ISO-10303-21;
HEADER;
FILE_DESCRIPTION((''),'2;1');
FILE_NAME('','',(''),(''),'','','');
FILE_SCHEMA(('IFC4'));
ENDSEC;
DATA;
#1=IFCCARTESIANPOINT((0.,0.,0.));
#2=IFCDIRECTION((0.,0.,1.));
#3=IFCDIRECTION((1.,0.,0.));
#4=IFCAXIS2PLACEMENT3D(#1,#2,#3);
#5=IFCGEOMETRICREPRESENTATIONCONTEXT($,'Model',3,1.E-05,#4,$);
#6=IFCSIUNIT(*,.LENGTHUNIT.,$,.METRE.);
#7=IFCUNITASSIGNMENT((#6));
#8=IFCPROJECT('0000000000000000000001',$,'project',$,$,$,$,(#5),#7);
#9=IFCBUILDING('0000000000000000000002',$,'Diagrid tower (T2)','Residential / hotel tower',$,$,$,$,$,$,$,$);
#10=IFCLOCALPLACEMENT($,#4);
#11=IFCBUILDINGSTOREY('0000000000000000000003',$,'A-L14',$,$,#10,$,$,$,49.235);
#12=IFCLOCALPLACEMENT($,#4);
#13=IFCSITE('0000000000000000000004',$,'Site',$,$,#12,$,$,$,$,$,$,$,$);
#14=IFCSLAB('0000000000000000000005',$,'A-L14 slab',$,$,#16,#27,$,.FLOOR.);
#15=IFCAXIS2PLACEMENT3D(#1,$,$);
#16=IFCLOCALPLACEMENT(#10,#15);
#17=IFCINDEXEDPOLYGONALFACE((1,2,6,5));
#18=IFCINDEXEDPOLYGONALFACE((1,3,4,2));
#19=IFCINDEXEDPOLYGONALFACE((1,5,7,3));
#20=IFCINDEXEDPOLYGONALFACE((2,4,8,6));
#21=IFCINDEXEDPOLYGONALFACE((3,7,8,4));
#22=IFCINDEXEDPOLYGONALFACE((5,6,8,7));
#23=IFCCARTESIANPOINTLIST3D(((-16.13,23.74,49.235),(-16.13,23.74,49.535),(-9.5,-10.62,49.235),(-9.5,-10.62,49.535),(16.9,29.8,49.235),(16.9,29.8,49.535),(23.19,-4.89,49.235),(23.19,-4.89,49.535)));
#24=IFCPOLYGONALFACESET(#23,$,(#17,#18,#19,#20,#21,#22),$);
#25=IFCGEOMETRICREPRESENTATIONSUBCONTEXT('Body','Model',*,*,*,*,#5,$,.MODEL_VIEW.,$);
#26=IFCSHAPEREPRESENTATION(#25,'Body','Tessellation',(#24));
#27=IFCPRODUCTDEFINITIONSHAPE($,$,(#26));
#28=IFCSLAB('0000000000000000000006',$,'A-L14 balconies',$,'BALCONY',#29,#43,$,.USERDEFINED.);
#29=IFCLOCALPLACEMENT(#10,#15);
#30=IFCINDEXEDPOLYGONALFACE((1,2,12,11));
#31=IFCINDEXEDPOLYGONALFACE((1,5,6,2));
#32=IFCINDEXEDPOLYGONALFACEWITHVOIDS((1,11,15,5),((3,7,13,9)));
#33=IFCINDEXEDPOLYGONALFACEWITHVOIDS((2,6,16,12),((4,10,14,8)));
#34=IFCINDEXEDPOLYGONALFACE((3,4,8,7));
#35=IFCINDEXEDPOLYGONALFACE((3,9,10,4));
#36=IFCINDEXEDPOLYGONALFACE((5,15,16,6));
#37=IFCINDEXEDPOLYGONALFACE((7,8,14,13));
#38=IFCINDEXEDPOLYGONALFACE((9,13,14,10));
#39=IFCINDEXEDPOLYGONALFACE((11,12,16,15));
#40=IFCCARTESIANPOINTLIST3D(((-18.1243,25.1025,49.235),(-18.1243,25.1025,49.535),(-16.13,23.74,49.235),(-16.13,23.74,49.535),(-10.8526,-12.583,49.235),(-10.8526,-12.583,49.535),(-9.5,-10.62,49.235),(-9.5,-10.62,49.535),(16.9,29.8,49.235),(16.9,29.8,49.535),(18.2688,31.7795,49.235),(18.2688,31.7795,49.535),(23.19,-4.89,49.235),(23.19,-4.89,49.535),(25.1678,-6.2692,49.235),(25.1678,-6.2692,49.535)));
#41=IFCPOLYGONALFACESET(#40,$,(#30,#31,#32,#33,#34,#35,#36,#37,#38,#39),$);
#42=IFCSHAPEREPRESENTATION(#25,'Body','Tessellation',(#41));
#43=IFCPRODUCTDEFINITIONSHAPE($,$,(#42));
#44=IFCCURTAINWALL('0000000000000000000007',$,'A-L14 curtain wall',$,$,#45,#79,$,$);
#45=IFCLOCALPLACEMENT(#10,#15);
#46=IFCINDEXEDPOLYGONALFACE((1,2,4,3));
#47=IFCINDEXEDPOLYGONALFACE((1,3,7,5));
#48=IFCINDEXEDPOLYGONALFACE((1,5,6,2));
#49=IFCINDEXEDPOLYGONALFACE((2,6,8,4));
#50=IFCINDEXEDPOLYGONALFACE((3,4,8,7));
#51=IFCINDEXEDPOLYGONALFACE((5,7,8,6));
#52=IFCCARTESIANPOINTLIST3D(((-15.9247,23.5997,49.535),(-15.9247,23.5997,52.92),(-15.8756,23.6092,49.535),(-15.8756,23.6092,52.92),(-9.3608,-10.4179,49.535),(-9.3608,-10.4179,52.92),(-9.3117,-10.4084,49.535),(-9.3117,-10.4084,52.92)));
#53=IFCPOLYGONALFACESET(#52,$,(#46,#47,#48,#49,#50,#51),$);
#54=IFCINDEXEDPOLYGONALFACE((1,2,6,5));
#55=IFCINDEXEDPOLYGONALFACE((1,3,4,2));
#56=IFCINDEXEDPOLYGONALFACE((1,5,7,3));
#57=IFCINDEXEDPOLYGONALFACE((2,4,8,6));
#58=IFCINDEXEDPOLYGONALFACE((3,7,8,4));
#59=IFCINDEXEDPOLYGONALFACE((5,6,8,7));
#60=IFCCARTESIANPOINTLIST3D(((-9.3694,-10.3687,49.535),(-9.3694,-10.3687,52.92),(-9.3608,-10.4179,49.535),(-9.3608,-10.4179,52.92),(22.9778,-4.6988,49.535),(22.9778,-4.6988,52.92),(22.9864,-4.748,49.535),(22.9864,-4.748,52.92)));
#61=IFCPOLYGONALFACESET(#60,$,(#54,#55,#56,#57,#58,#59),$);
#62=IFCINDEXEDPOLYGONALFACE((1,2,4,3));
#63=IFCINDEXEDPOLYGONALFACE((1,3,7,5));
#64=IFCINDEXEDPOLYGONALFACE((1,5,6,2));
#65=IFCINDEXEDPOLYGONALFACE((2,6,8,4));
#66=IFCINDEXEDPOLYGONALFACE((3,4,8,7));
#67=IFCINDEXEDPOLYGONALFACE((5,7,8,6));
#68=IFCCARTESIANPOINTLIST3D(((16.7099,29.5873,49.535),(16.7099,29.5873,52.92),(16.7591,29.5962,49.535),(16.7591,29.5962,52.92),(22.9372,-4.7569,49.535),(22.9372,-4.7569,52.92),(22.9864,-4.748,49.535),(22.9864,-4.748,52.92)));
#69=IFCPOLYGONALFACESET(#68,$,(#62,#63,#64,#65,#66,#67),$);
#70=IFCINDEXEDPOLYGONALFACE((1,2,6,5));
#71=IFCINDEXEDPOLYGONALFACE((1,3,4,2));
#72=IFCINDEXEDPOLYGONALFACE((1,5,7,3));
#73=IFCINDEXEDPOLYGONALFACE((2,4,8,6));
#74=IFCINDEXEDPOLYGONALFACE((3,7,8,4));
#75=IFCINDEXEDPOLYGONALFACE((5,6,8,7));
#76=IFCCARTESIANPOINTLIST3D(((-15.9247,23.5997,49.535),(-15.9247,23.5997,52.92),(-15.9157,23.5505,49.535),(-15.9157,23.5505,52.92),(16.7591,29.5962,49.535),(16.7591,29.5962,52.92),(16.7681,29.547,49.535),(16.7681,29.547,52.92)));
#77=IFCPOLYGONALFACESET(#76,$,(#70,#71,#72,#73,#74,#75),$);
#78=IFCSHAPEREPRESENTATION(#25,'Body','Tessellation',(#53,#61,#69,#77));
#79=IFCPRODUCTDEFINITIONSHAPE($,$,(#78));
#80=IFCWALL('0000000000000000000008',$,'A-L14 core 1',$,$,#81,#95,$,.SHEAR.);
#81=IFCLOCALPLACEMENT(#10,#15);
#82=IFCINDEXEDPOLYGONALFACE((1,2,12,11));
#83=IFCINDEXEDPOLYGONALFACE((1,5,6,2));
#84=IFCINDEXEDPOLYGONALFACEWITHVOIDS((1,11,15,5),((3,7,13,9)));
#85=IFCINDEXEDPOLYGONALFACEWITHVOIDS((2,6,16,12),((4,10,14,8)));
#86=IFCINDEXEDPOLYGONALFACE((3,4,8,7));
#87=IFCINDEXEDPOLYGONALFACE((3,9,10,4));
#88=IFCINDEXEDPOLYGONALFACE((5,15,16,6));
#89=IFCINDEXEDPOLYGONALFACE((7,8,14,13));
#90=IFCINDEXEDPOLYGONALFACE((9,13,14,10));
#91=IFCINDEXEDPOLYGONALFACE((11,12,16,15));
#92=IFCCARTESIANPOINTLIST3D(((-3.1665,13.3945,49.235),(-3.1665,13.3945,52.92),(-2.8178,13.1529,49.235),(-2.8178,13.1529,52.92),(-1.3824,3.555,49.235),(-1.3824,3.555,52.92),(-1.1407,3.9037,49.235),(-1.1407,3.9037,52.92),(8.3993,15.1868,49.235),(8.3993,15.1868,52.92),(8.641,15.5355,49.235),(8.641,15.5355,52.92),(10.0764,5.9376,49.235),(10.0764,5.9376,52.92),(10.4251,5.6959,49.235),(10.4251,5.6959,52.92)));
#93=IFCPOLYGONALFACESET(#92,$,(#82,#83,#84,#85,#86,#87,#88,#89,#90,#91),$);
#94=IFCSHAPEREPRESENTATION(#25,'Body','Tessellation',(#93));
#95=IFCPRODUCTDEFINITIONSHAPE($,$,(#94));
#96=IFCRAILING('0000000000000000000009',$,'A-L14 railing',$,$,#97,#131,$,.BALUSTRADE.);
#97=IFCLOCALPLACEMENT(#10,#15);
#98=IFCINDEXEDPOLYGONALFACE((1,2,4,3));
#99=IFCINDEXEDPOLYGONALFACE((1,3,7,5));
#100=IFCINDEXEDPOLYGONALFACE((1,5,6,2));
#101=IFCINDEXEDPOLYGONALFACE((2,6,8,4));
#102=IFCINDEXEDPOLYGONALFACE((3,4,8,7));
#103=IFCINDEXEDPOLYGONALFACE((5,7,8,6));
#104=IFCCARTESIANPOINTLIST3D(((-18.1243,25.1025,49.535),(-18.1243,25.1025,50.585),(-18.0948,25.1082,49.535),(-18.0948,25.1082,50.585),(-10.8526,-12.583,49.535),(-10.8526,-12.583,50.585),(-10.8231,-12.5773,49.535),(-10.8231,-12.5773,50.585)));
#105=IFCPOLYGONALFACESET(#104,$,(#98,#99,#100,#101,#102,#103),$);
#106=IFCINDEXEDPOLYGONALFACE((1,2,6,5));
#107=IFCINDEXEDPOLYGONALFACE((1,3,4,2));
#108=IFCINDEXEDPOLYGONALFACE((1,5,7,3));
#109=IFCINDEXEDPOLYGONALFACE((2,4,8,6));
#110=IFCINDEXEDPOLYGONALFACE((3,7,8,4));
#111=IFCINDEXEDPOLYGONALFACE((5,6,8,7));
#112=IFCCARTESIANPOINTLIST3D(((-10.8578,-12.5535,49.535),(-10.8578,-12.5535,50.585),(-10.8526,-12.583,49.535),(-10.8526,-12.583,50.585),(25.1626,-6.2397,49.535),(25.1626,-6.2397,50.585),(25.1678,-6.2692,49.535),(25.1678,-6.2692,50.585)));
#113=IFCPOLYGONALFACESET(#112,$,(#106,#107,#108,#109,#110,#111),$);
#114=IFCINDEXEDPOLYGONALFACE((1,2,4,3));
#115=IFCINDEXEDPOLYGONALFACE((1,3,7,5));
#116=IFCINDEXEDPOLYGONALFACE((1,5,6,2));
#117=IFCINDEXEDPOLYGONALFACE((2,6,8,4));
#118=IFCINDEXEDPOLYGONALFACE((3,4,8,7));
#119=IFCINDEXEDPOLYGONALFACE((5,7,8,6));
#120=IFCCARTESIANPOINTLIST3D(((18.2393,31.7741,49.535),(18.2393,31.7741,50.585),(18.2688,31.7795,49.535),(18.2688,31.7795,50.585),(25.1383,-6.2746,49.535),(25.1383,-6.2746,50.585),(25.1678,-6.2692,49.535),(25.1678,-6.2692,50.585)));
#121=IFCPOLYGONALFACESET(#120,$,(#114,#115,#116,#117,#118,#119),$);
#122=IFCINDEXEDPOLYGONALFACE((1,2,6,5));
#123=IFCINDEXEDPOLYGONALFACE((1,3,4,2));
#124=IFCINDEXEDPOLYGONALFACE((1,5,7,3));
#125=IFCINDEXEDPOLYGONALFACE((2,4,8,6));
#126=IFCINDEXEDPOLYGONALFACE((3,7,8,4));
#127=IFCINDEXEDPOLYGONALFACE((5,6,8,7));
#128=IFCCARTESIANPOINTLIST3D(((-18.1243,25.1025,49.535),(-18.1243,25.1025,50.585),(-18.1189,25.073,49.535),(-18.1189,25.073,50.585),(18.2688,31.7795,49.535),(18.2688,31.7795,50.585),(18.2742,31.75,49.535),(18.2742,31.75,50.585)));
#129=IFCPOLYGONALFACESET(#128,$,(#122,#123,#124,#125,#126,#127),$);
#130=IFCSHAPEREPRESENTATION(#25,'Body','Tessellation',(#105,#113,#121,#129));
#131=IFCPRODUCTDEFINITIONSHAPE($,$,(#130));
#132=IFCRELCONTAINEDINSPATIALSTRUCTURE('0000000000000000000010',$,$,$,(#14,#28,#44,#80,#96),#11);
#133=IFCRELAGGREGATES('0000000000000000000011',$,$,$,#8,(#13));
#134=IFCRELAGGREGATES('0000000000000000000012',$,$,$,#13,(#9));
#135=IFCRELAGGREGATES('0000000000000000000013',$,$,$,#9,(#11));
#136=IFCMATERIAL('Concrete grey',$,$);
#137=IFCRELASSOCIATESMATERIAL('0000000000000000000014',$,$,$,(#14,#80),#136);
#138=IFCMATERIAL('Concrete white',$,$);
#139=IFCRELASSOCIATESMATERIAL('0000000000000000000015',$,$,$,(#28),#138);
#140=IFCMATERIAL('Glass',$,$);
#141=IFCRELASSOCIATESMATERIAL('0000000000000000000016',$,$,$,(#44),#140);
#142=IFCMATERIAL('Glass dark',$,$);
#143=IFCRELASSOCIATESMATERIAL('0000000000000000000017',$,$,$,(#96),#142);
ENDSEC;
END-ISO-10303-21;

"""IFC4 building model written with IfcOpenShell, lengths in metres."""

from ifc_helpers import new_model, si_unit, frame, origin_with_axes, place, context, subcontext, project, spatial, polyline, outline, extrude, material, element, save


model = new_model("IFC4")

# Units and contexts
model_context = context("Model", 3, precision=1e-05, world=origin_with_axes())
body_context = subcontext(model_context, "Body", "Model", "MODEL_VIEW")
ifc_project = project(units=[si_unit("LENGTHUNIT", "METRE")], contexts=[model_context])

# Site, building, storey
site_placement = place(None, origin_with_axes())
site = spatial("IfcSite", under=ifc_project, at=site_placement, Name="Site")
building = spatial("IfcBuilding", under=site, Name="Diagrid tower (T2)", Description="Residential / hotel tower")
storey_placement = place(None, origin_with_axes())
storey = spatial("IfcBuildingStorey", under=building, at=storey_placement, Name="A-L14", Elevation=49.235)

# Slabs
ifc_material_1 = material(Name="Concrete grey")
slab_1_placement = place(storey_placement, origin_with_axes())
element("IfcSlab", 1, at=slab_1_placement, inside=storey, material=ifc_material_1, Name="A-L14 slab", PredefinedType="FLOOR", context=body_context, shape_type="SweptSolid", body=[
    extrude(outline(polyline([(-16.13, 23.74), (-9.5, -10.62), (23.19, -4.89), (16.9, 29.8), (-16.13, 23.74)])), frame((0.0, 0.0, 49.235), z_axis=(0.0, 0.0, 1.0), x_axis=(1.0, 0.0, 0.0)), (0.0, 0.0, 1.0), 0.3),
])
ifc_material_2 = material(Name="Concrete white")
slab_2_placement = place(storey_placement, origin_with_axes())
element("IfcSlab", 2, at=slab_2_placement, inside=storey, material=ifc_material_2, Name="A-L14 balconies", ObjectType="BALCONY", PredefinedType="USERDEFINED", context=body_context, shape_type="SweptSolid", body=[
    extrude(outline(polyline([(-18.1243, 25.1025), (-10.8526, -12.583), (25.1678, -6.2692), (18.2688, 31.7795), (-18.1243, 25.1025)]), holes=[polyline([(-16.13, 23.74), (-9.5, -10.62), (23.19, -4.89), (16.9, 29.8), (-16.13, 23.74)])]), frame((0.0, 0.0, 49.235), z_axis=(0.0, 0.0, 1.0), x_axis=(1.0, 0.0, 0.0)), (0.0, 0.0, 1.0), 0.3),
])

# Curtain wall
ifc_material_3 = material(Name="Glass")
curtain_wall_placement = place(storey_placement, origin_with_axes())
element("IfcCurtainWall", 3, at=curtain_wall_placement, inside=storey, material=ifc_material_3, Name="A-L14 curtain wall", context=body_context, shape_type="SweptSolid", body=[
    extrude(outline(polyline([(-15.9247, 23.5997), (-9.3608, -10.4179), (-9.3117, -10.4084), (-15.8756, 23.6092), (-15.9247, 23.5997)])), frame((0.0, 0.0, 49.535), z_axis=(0.0, 0.0, 1.0), x_axis=(1.0, 0.0, 0.0)), (0.0, 0.0, 1.0), 3.385),
    extrude(outline(polyline([(-9.3608, -10.4179), (22.9864, -4.748), (22.9778, -4.6988), (-9.3694, -10.3687), (-9.3608, -10.4179)])), frame((0.0, 0.0, 49.535), z_axis=(0.0, 0.0, 1.0), x_axis=(1.0, 0.0, 0.0)), (0.0, 0.0, 1.0), 3.385),
    extrude(outline(polyline([(22.9864, -4.748), (16.7591, 29.5962), (16.7099, 29.5873), (22.9372, -4.7569), (22.9864, -4.748)])), frame((0.0, 0.0, 49.535), z_axis=(0.0, 0.0, 1.0), x_axis=(1.0, 0.0, 0.0)), (0.0, 0.0, 1.0), 3.385),
    extrude(outline(polyline([(16.7591, 29.5962), (-15.9247, 23.5997), (-15.9157, 23.5505), (16.7681, 29.547), (16.7591, 29.5962)])), frame((0.0, 0.0, 49.535), z_axis=(0.0, 0.0, 1.0), x_axis=(1.0, 0.0, 0.0)), (0.0, 0.0, 1.0), 3.385),
])

# Wall
wall_placement = place(storey_placement, origin_with_axes())
element("IfcWall", 4, at=wall_placement, inside=storey, material=ifc_material_1, Name="A-L14 core 1", PredefinedType="SHEAR", context=body_context, shape_type="SweptSolid", body=[
    extrude(outline(polyline([(10.4251, 5.6959), (8.641, 15.5355), (-3.1665, 13.3945), (-1.3824, 3.555), (10.4251, 5.6959)]), holes=[polyline([(10.0764, 5.9376), (8.3993, 15.1868), (-2.8178, 13.1529), (-1.1407, 3.9037), (10.0764, 5.9376)])]), frame((0.0, 0.0, 49.235), z_axis=(0.0, 0.0, 1.0), x_axis=(1.0, 0.0, 0.0)), (0.0, 0.0, 1.0), 3.685),
])

# Railing
ifc_material_4 = material(Name="Glass dark")
railing_placement = place(storey_placement, origin_with_axes())
element("IfcRailing", 5, at=railing_placement, inside=storey, material=ifc_material_4, Name="A-L14 railing", PredefinedType="BALUSTRADE", context=body_context, shape_type="SweptSolid", body=[
    extrude(outline(polyline([(-18.1243, 25.1025), (-10.8526, -12.583), (-10.8231, -12.5773), (-18.0948, 25.1082), (-18.1243, 25.1025)])), frame((0.0, 0.0, 49.535), z_axis=(0.0, 0.0, 1.0), x_axis=(1.0, 0.0, 0.0)), (0.0, 0.0, 1.0), 1.05),
    extrude(outline(polyline([(-10.8526, -12.583), (25.1678, -6.2692), (25.1626, -6.2397), (-10.8578, -12.5535), (-10.8526, -12.583)])), frame((0.0, 0.0, 49.535), z_axis=(0.0, 0.0, 1.0), x_axis=(1.0, 0.0, 0.0)), (0.0, 0.0, 1.0), 1.05),
    extrude(outline(polyline([(25.1678, -6.2692), (18.2688, 31.7795), (18.2393, 31.7741), (25.1383, -6.2746), (25.1678, -6.2692)])), frame((0.0, 0.0, 49.535), z_axis=(0.0, 0.0, 1.0), x_axis=(1.0, 0.0, 0.0)), (0.0, 0.0, 1.0), 1.05),
    extrude(outline(polyline([(18.2688, 31.7795), (-18.1243, 25.1025), (-18.1189, 25.073), (18.2742, 31.75), (18.2688, 31.7795)])), frame((0.0, 0.0, 49.535), z_axis=(0.0, 0.0, 1.0), x_axis=(1.0, 0.0, 0.0)), (0.0, 0.0, 1.0), 1.05),
])

save(model, "model.ifc")
